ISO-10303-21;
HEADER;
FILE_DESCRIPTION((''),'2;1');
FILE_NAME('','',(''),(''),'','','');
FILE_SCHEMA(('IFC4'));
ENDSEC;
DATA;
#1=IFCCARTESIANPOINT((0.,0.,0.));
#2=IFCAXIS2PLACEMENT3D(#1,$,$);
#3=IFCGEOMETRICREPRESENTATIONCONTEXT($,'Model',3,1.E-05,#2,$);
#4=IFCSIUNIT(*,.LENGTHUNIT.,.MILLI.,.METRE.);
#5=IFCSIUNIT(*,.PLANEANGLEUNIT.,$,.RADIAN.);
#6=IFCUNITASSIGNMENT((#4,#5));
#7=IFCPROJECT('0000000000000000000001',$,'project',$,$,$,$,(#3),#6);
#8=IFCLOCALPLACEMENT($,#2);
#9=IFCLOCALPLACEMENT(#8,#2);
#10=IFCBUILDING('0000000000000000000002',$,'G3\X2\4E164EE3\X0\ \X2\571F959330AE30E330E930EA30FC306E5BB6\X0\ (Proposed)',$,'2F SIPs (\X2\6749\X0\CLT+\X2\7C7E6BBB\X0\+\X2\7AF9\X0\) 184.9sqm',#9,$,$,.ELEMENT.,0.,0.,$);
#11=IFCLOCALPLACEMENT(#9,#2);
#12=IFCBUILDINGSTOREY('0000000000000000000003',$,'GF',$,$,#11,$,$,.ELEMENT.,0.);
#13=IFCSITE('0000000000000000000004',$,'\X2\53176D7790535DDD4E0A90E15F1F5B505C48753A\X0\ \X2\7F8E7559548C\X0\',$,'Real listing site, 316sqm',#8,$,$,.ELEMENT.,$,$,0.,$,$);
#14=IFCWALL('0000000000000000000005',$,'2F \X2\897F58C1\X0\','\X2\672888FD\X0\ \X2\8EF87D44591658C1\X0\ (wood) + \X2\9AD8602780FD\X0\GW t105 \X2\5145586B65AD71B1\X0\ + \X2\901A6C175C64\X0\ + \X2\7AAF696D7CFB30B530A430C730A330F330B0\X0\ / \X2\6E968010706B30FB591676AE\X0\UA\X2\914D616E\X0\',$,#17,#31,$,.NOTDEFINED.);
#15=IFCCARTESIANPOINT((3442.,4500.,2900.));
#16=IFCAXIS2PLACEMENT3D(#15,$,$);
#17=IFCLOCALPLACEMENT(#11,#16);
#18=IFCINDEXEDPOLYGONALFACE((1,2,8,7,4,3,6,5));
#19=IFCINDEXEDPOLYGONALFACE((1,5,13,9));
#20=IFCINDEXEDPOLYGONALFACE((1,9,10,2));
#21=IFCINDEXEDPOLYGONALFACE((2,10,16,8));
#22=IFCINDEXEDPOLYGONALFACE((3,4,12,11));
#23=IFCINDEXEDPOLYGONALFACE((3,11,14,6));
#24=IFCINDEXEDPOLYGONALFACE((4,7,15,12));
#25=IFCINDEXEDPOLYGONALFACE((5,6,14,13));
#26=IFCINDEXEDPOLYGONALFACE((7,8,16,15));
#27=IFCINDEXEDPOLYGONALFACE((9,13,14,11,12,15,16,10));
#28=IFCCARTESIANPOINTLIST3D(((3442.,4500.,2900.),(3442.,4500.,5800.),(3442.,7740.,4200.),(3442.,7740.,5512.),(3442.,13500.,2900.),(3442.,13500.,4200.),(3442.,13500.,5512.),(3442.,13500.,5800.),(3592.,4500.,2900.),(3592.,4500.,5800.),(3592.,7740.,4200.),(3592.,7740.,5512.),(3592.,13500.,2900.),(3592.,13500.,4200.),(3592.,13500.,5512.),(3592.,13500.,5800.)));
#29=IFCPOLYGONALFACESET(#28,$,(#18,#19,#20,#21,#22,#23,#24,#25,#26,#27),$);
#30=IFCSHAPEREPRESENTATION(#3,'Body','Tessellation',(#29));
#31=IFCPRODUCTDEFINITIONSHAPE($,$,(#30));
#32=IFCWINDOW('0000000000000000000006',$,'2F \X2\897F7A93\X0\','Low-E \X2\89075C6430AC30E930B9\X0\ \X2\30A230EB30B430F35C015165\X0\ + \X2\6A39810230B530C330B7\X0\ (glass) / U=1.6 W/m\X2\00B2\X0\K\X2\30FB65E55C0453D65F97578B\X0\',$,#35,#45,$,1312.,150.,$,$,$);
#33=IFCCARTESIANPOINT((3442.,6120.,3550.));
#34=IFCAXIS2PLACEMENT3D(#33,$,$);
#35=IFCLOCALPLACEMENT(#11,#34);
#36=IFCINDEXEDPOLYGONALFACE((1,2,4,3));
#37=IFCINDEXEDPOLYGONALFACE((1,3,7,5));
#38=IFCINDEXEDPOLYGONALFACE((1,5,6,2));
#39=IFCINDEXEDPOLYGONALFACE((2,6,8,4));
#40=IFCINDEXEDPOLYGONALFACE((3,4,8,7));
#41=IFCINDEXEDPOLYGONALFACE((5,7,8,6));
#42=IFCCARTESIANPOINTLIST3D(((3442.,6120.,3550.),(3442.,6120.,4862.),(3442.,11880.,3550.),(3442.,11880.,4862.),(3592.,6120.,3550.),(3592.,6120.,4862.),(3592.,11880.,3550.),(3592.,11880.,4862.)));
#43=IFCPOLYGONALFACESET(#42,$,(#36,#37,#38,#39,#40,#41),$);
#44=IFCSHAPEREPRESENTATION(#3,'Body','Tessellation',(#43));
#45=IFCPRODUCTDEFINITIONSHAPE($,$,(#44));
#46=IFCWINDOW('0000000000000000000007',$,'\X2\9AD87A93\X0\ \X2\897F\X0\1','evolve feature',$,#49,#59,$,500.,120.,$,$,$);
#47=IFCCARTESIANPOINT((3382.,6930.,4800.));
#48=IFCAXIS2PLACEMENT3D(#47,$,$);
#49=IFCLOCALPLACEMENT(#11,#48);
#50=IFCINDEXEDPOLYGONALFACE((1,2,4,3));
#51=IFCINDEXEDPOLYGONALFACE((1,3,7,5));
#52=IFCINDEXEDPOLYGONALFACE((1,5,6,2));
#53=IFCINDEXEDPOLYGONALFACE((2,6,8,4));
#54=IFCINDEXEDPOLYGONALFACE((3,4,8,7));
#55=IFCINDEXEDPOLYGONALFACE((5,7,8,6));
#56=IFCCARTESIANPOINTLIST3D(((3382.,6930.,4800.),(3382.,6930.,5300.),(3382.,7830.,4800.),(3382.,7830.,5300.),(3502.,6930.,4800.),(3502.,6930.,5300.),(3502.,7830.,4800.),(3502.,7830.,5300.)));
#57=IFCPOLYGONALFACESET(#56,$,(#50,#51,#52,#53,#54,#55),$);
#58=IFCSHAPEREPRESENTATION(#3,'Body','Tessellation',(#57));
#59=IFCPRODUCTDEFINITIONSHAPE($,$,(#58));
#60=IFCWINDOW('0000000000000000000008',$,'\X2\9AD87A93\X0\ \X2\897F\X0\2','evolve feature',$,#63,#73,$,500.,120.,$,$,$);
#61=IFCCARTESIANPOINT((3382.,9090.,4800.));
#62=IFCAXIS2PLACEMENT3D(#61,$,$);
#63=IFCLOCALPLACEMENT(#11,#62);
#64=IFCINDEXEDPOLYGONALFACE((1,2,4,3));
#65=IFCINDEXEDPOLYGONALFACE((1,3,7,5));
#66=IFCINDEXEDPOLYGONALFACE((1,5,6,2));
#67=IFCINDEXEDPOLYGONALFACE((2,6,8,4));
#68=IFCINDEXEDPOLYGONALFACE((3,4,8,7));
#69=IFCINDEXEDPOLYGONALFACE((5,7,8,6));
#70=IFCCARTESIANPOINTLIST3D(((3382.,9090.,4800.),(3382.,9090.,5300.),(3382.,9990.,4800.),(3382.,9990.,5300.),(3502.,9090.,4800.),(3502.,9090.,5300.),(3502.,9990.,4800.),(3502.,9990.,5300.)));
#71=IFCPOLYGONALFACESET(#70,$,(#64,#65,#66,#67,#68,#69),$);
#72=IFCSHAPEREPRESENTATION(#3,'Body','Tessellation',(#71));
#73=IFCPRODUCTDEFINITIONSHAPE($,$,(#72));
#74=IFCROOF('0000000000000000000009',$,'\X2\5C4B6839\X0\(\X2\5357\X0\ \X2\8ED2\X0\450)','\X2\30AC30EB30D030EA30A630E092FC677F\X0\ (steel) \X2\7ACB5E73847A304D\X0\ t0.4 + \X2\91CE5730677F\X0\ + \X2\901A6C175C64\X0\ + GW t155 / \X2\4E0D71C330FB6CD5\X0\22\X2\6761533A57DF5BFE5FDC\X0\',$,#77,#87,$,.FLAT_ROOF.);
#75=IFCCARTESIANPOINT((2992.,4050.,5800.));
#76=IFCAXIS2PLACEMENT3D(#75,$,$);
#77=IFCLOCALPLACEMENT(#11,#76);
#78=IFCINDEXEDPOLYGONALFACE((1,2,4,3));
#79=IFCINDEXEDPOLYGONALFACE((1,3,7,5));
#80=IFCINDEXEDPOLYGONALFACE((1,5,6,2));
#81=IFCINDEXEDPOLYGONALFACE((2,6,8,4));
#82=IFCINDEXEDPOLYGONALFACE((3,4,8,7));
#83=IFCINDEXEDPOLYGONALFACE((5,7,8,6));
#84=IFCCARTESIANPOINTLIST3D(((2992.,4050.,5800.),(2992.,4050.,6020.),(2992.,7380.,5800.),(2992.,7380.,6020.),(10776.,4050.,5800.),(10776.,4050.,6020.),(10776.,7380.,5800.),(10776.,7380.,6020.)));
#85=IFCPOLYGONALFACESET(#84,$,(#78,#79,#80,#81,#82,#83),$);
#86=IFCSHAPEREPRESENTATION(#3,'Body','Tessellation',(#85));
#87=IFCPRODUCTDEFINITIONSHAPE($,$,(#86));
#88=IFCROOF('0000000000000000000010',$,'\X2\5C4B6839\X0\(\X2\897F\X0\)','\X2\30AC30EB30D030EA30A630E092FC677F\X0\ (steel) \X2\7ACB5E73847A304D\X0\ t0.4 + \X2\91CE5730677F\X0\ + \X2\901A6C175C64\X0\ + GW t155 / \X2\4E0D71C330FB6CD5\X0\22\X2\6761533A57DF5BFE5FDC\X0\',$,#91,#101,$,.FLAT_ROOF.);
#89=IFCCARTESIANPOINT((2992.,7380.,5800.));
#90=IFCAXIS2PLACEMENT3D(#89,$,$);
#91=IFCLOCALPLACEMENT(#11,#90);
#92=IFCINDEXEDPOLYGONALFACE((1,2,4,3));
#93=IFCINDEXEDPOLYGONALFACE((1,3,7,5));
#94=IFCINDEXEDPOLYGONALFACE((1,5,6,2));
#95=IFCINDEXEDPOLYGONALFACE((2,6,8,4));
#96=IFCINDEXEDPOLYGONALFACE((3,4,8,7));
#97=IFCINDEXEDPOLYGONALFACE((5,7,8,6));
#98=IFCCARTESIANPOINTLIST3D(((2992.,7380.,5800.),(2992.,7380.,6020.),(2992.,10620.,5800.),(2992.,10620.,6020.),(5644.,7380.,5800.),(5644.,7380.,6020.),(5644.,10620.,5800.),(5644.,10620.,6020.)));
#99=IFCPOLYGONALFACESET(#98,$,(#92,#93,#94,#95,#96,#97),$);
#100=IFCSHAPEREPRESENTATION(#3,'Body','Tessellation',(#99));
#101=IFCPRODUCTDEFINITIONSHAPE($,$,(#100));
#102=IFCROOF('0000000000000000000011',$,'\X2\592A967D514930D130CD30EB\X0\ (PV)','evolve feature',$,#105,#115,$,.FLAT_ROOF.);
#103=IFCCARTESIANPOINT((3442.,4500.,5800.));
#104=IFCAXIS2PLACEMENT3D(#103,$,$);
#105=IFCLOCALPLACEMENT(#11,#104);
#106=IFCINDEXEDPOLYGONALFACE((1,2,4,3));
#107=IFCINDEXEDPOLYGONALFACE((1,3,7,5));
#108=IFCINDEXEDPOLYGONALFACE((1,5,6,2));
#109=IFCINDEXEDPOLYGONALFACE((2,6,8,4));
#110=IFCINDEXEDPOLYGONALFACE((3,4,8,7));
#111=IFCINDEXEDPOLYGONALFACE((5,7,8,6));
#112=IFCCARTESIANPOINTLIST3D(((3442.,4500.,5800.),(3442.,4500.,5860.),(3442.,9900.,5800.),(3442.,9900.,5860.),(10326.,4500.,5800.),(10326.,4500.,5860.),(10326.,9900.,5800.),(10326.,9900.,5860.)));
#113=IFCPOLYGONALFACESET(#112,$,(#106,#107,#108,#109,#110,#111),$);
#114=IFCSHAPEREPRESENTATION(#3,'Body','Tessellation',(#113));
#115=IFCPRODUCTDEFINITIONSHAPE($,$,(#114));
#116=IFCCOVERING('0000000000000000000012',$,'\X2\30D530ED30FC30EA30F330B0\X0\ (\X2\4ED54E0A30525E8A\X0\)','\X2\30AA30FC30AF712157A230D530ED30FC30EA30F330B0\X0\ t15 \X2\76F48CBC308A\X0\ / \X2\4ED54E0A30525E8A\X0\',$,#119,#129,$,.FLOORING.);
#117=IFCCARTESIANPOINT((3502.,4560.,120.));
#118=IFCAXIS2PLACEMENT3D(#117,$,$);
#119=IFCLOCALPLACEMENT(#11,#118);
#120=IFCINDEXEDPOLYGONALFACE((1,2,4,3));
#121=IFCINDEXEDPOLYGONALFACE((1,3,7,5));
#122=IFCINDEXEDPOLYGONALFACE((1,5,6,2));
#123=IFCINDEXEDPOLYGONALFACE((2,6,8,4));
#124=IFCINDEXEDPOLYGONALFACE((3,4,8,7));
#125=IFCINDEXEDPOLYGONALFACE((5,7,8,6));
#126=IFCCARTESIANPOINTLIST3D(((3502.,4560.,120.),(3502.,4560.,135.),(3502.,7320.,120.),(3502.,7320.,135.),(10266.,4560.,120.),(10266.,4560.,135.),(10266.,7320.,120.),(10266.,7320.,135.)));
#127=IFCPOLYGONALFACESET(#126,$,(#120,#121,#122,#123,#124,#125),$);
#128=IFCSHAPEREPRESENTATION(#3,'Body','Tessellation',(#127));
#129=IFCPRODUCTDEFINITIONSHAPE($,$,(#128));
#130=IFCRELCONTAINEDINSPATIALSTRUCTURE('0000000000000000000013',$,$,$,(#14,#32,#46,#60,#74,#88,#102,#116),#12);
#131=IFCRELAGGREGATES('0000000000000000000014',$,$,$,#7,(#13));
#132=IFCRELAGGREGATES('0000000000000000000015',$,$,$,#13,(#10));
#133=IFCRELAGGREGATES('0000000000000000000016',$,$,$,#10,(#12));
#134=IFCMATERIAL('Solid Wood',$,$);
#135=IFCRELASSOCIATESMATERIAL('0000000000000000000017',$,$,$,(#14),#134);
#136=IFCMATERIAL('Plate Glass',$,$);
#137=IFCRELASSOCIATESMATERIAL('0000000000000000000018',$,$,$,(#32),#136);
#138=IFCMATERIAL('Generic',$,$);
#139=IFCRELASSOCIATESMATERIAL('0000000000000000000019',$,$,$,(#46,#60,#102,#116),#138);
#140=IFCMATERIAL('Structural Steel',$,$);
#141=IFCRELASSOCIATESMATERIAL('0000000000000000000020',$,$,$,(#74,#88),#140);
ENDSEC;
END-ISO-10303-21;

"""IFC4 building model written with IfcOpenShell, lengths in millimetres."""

from ifc_helpers import new_model, si_unit, frame, frame_2d, origin, place, context, project, spatial, rectangle, extrude, material, element, fill, save


model = new_model("IFC4")

# Units and contexts
model_context = context("Model", 3, precision=1e-05, world=origin())
ifc_project = project(units=[si_unit("LENGTHUNIT", "METRE", prefix="MILLI"), si_unit("PLANEANGLEUNIT", "RADIAN")], contexts=[model_context])

# Site, building, storey
site_placement = place(None, origin())
site = spatial("IfcSite", under=ifc_project, at=site_placement, Name="北海道川上郡弟子屈町 美留和", ObjectType="Real listing site, 316sqm", CompositionType="ELEMENT", RefElevation=0.0)
building_placement = place(site_placement, origin())
building = spatial("IfcBuilding", under=site, at=building_placement, Name="G3世代 土間ギャラリーの家 (Proposed)", ObjectType="2F SIPs (杉CLT+籾殻+竹) 184.9sqm", CompositionType="ELEMENT", ElevationOfRefHeight=0.0, ElevationOfTerrain=0.0)
storey_placement = place(building_placement, origin())
storey = spatial("IfcBuildingStorey", under=building, at=storey_placement, Name="GF", CompositionType="ELEMENT", Elevation=0.0)

# Shared definitions
ifc_material_1 = material(Name="Solid Wood")
ifc_material_2 = material(Name="Generic")

# Shared definitions
ifc_material_3 = material(Name="Plate Glass")

# Wall, openings, windows
wall_1_placement = place(storey_placement, frame((3442.0, 4500.0, 2900.0)))
wall_1 = element("IfcWall", 1, at=wall_1_placement, inside=storey, material=ifc_material_1, Name="2F 西壁", Description="木製 軸組外壁 (wood) + 高性能GW t105 充填断熱 + 通気層 + 窯業系サイディング / 準耐火・外皮UA配慮", PredefinedType="NOTDEFINED", context=model_context, shape_type="SweptSolid", body=[
    extrude(rectangle(XDim=150.0, YDim=9000.0, at=frame_2d((75.0, 4500.0))), frame((3442.0, 4500.0, 2900.0)), (0.0, 0.0, 1.0), 2900.0),
])
opening_1_placement = place(storey_placement, frame((3442.0, 6120.0, 3550.0)))
opening_1 = element("IfcOpeningElement", 2, at=opening_1_placement, cuts=wall_1, PredefinedType="NOTDEFINED", context=model_context, shape_type="SweptSolid", body=[
    extrude(rectangle(XDim=150.0, YDim=5760.0, at=frame_2d((75.0, 2880.0))), frame((3442.0, 6120.0, 3550.0)), (0.0, 0.0, 1.0), 1312.0),
])
opening_2_placement = place(storey_placement, frame((3382.0, 6930.0, 4800.0)))
opening_2 = element("IfcOpeningElement", 3, at=opening_2_placement, cuts=wall_1, PredefinedType="NOTDEFINED", context=model_context, shape_type="SweptSolid", body=[
    extrude(rectangle(XDim=120.0, YDim=900.0, at=frame_2d((60.0, 450.0))), frame((3382.0, 6930.0, 4800.0)), (0.0, 0.0, 1.0), 500.0),
])
opening_3_placement = place(storey_placement, frame((3382.0, 9090.0, 4800.0)))
opening_3 = element("IfcOpeningElement", 4, at=opening_3_placement, cuts=wall_1, PredefinedType="NOTDEFINED", context=model_context, shape_type="SweptSolid", body=[
    extrude(rectangle(XDim=120.0, YDim=900.0, at=frame_2d((60.0, 450.0))), frame((3382.0, 9090.0, 4800.0)), (0.0, 0.0, 1.0), 500.0),
])
window_1_placement = place(storey_placement, frame((3442.0, 6120.0, 3550.0)))
window_1 = element("IfcWindow", 5, at=window_1_placement, inside=storey, material=ifc_material_3, Name="2F 西窓", Description="Low-E 複層ガラス アルゴン封入 + 樹脂サッシ (glass) / U=1.6 W/m²K・日射取得型", OverallHeight=1312.0, OverallWidth=150.0, context=model_context, shape_type="SweptSolid", body=[
    extrude(rectangle(XDim=150.0, YDim=5760.0, at=frame_2d((75.0, 2880.0))), frame((3442.0, 6120.0, 3550.0)), (0.0, 0.0, 1.0), 1312.0),
])
fill(opening_1, window_1)
window_2_placement = place(storey_placement, frame((3382.0, 6930.0, 4800.0)))
window_2 = element("IfcWindow", 6, at=window_2_placement, inside=storey, material=ifc_material_2, Name="高窓 西1", Description="evolve feature", OverallHeight=500.0, OverallWidth=120.0, context=model_context, shape_type="SweptSolid", body=[
    extrude(rectangle(XDim=120.0, YDim=900.0, at=frame_2d((60.0, 450.0))), frame((3382.0, 6930.0, 4800.0)), (0.0, 0.0, 1.0), 500.0),
])
fill(opening_2, window_2)
window_3_placement = place(storey_placement, frame((3382.0, 9090.0, 4800.0)))
window_3 = element("IfcWindow", 7, at=window_3_placement, inside=storey, material=ifc_material_2, Name="高窓 西2", Description="evolve feature", OverallHeight=500.0, OverallWidth=120.0, context=model_context, shape_type="SweptSolid", body=[
    extrude(rectangle(XDim=120.0, YDim=900.0, at=frame_2d((60.0, 450.0))), frame((3382.0, 9090.0, 4800.0)), (0.0, 0.0, 1.0), 500.0),
])
fill(opening_3, window_3)

# Roofs
ifc_material_4 = material(Name="Structural Steel")
roof_1_placement = place(storey_placement, frame((2992.0, 4050.0, 5800.0)))
element("IfcRoof", 8, at=roof_1_placement, inside=storey, material=ifc_material_4, Name="屋根(南 軒450)", Description="ガルバリウム鋼板 (steel) 立平葺き t0.4 + 野地板 + 通気層 + GW t155 / 不燃・法22条区域対応", PredefinedType="FLAT_ROOF", context=model_context, shape_type="SweptSolid", body=[
    extrude(rectangle(XDim=7784.0, YDim=3330.0, at=frame_2d((3892.0, 1665.0))), frame((2992.0, 4050.0, 5800.0)), (0.0, 0.0, 1.0), 220.0),
])
roof_2_placement = place(storey_placement, frame((2992.0, 7380.0, 5800.0)))
element("IfcRoof", 9, at=roof_2_placement, inside=storey, material=ifc_material_4, Name="屋根(西)", Description="ガルバリウム鋼板 (steel) 立平葺き t0.4 + 野地板 + 通気層 + GW t155 / 不燃・法22条区域対応", PredefinedType="FLAT_ROOF", context=model_context, shape_type="SweptSolid", body=[
    extrude(rectangle(XDim=2652.0, YDim=3240.0, at=frame_2d((1326.0, 1620.0))), frame((2992.0, 7380.0, 5800.0)), (0.0, 0.0, 1.0), 220.0),
])
roof_3_placement = place(storey_placement, frame((3442.0, 4500.0, 5800.0)))
element("IfcRoof", 10, at=roof_3_placement, inside=storey, material=ifc_material_2, Name="太陽光パネル (PV)", Description="evolve feature", PredefinedType="FLAT_ROOF", context=model_context, shape_type="SweptSolid", body=[
    extrude(rectangle(XDim=6884.0, YDim=5400.0, at=frame_2d((3442.0, 2700.0))), frame((3442.0, 4500.0, 5800.0)), (0.0, 0.0, 1.0), 60.0),
])

# Covering
covering_placement = place(storey_placement, frame((3502.0, 4560.0, 120.0)))
element("IfcCovering", 11, at=covering_placement, inside=storey, material=ifc_material_2, Name="フローリング (仕上げ床)", Description="オーク無垢フローリング t15 直貼り / 仕上げ床", PredefinedType="FLOORING", context=model_context, shape_type="SweptSolid", body=[
    extrude(rectangle(XDim=6764.0, YDim=2760.0, at=frame_2d((3382.0, 1380.0))), frame((3502.0, 4560.0, 120.0)), (0.0, 0.0, 1.0), 15.0),
])

save(model, "model.ifc")
